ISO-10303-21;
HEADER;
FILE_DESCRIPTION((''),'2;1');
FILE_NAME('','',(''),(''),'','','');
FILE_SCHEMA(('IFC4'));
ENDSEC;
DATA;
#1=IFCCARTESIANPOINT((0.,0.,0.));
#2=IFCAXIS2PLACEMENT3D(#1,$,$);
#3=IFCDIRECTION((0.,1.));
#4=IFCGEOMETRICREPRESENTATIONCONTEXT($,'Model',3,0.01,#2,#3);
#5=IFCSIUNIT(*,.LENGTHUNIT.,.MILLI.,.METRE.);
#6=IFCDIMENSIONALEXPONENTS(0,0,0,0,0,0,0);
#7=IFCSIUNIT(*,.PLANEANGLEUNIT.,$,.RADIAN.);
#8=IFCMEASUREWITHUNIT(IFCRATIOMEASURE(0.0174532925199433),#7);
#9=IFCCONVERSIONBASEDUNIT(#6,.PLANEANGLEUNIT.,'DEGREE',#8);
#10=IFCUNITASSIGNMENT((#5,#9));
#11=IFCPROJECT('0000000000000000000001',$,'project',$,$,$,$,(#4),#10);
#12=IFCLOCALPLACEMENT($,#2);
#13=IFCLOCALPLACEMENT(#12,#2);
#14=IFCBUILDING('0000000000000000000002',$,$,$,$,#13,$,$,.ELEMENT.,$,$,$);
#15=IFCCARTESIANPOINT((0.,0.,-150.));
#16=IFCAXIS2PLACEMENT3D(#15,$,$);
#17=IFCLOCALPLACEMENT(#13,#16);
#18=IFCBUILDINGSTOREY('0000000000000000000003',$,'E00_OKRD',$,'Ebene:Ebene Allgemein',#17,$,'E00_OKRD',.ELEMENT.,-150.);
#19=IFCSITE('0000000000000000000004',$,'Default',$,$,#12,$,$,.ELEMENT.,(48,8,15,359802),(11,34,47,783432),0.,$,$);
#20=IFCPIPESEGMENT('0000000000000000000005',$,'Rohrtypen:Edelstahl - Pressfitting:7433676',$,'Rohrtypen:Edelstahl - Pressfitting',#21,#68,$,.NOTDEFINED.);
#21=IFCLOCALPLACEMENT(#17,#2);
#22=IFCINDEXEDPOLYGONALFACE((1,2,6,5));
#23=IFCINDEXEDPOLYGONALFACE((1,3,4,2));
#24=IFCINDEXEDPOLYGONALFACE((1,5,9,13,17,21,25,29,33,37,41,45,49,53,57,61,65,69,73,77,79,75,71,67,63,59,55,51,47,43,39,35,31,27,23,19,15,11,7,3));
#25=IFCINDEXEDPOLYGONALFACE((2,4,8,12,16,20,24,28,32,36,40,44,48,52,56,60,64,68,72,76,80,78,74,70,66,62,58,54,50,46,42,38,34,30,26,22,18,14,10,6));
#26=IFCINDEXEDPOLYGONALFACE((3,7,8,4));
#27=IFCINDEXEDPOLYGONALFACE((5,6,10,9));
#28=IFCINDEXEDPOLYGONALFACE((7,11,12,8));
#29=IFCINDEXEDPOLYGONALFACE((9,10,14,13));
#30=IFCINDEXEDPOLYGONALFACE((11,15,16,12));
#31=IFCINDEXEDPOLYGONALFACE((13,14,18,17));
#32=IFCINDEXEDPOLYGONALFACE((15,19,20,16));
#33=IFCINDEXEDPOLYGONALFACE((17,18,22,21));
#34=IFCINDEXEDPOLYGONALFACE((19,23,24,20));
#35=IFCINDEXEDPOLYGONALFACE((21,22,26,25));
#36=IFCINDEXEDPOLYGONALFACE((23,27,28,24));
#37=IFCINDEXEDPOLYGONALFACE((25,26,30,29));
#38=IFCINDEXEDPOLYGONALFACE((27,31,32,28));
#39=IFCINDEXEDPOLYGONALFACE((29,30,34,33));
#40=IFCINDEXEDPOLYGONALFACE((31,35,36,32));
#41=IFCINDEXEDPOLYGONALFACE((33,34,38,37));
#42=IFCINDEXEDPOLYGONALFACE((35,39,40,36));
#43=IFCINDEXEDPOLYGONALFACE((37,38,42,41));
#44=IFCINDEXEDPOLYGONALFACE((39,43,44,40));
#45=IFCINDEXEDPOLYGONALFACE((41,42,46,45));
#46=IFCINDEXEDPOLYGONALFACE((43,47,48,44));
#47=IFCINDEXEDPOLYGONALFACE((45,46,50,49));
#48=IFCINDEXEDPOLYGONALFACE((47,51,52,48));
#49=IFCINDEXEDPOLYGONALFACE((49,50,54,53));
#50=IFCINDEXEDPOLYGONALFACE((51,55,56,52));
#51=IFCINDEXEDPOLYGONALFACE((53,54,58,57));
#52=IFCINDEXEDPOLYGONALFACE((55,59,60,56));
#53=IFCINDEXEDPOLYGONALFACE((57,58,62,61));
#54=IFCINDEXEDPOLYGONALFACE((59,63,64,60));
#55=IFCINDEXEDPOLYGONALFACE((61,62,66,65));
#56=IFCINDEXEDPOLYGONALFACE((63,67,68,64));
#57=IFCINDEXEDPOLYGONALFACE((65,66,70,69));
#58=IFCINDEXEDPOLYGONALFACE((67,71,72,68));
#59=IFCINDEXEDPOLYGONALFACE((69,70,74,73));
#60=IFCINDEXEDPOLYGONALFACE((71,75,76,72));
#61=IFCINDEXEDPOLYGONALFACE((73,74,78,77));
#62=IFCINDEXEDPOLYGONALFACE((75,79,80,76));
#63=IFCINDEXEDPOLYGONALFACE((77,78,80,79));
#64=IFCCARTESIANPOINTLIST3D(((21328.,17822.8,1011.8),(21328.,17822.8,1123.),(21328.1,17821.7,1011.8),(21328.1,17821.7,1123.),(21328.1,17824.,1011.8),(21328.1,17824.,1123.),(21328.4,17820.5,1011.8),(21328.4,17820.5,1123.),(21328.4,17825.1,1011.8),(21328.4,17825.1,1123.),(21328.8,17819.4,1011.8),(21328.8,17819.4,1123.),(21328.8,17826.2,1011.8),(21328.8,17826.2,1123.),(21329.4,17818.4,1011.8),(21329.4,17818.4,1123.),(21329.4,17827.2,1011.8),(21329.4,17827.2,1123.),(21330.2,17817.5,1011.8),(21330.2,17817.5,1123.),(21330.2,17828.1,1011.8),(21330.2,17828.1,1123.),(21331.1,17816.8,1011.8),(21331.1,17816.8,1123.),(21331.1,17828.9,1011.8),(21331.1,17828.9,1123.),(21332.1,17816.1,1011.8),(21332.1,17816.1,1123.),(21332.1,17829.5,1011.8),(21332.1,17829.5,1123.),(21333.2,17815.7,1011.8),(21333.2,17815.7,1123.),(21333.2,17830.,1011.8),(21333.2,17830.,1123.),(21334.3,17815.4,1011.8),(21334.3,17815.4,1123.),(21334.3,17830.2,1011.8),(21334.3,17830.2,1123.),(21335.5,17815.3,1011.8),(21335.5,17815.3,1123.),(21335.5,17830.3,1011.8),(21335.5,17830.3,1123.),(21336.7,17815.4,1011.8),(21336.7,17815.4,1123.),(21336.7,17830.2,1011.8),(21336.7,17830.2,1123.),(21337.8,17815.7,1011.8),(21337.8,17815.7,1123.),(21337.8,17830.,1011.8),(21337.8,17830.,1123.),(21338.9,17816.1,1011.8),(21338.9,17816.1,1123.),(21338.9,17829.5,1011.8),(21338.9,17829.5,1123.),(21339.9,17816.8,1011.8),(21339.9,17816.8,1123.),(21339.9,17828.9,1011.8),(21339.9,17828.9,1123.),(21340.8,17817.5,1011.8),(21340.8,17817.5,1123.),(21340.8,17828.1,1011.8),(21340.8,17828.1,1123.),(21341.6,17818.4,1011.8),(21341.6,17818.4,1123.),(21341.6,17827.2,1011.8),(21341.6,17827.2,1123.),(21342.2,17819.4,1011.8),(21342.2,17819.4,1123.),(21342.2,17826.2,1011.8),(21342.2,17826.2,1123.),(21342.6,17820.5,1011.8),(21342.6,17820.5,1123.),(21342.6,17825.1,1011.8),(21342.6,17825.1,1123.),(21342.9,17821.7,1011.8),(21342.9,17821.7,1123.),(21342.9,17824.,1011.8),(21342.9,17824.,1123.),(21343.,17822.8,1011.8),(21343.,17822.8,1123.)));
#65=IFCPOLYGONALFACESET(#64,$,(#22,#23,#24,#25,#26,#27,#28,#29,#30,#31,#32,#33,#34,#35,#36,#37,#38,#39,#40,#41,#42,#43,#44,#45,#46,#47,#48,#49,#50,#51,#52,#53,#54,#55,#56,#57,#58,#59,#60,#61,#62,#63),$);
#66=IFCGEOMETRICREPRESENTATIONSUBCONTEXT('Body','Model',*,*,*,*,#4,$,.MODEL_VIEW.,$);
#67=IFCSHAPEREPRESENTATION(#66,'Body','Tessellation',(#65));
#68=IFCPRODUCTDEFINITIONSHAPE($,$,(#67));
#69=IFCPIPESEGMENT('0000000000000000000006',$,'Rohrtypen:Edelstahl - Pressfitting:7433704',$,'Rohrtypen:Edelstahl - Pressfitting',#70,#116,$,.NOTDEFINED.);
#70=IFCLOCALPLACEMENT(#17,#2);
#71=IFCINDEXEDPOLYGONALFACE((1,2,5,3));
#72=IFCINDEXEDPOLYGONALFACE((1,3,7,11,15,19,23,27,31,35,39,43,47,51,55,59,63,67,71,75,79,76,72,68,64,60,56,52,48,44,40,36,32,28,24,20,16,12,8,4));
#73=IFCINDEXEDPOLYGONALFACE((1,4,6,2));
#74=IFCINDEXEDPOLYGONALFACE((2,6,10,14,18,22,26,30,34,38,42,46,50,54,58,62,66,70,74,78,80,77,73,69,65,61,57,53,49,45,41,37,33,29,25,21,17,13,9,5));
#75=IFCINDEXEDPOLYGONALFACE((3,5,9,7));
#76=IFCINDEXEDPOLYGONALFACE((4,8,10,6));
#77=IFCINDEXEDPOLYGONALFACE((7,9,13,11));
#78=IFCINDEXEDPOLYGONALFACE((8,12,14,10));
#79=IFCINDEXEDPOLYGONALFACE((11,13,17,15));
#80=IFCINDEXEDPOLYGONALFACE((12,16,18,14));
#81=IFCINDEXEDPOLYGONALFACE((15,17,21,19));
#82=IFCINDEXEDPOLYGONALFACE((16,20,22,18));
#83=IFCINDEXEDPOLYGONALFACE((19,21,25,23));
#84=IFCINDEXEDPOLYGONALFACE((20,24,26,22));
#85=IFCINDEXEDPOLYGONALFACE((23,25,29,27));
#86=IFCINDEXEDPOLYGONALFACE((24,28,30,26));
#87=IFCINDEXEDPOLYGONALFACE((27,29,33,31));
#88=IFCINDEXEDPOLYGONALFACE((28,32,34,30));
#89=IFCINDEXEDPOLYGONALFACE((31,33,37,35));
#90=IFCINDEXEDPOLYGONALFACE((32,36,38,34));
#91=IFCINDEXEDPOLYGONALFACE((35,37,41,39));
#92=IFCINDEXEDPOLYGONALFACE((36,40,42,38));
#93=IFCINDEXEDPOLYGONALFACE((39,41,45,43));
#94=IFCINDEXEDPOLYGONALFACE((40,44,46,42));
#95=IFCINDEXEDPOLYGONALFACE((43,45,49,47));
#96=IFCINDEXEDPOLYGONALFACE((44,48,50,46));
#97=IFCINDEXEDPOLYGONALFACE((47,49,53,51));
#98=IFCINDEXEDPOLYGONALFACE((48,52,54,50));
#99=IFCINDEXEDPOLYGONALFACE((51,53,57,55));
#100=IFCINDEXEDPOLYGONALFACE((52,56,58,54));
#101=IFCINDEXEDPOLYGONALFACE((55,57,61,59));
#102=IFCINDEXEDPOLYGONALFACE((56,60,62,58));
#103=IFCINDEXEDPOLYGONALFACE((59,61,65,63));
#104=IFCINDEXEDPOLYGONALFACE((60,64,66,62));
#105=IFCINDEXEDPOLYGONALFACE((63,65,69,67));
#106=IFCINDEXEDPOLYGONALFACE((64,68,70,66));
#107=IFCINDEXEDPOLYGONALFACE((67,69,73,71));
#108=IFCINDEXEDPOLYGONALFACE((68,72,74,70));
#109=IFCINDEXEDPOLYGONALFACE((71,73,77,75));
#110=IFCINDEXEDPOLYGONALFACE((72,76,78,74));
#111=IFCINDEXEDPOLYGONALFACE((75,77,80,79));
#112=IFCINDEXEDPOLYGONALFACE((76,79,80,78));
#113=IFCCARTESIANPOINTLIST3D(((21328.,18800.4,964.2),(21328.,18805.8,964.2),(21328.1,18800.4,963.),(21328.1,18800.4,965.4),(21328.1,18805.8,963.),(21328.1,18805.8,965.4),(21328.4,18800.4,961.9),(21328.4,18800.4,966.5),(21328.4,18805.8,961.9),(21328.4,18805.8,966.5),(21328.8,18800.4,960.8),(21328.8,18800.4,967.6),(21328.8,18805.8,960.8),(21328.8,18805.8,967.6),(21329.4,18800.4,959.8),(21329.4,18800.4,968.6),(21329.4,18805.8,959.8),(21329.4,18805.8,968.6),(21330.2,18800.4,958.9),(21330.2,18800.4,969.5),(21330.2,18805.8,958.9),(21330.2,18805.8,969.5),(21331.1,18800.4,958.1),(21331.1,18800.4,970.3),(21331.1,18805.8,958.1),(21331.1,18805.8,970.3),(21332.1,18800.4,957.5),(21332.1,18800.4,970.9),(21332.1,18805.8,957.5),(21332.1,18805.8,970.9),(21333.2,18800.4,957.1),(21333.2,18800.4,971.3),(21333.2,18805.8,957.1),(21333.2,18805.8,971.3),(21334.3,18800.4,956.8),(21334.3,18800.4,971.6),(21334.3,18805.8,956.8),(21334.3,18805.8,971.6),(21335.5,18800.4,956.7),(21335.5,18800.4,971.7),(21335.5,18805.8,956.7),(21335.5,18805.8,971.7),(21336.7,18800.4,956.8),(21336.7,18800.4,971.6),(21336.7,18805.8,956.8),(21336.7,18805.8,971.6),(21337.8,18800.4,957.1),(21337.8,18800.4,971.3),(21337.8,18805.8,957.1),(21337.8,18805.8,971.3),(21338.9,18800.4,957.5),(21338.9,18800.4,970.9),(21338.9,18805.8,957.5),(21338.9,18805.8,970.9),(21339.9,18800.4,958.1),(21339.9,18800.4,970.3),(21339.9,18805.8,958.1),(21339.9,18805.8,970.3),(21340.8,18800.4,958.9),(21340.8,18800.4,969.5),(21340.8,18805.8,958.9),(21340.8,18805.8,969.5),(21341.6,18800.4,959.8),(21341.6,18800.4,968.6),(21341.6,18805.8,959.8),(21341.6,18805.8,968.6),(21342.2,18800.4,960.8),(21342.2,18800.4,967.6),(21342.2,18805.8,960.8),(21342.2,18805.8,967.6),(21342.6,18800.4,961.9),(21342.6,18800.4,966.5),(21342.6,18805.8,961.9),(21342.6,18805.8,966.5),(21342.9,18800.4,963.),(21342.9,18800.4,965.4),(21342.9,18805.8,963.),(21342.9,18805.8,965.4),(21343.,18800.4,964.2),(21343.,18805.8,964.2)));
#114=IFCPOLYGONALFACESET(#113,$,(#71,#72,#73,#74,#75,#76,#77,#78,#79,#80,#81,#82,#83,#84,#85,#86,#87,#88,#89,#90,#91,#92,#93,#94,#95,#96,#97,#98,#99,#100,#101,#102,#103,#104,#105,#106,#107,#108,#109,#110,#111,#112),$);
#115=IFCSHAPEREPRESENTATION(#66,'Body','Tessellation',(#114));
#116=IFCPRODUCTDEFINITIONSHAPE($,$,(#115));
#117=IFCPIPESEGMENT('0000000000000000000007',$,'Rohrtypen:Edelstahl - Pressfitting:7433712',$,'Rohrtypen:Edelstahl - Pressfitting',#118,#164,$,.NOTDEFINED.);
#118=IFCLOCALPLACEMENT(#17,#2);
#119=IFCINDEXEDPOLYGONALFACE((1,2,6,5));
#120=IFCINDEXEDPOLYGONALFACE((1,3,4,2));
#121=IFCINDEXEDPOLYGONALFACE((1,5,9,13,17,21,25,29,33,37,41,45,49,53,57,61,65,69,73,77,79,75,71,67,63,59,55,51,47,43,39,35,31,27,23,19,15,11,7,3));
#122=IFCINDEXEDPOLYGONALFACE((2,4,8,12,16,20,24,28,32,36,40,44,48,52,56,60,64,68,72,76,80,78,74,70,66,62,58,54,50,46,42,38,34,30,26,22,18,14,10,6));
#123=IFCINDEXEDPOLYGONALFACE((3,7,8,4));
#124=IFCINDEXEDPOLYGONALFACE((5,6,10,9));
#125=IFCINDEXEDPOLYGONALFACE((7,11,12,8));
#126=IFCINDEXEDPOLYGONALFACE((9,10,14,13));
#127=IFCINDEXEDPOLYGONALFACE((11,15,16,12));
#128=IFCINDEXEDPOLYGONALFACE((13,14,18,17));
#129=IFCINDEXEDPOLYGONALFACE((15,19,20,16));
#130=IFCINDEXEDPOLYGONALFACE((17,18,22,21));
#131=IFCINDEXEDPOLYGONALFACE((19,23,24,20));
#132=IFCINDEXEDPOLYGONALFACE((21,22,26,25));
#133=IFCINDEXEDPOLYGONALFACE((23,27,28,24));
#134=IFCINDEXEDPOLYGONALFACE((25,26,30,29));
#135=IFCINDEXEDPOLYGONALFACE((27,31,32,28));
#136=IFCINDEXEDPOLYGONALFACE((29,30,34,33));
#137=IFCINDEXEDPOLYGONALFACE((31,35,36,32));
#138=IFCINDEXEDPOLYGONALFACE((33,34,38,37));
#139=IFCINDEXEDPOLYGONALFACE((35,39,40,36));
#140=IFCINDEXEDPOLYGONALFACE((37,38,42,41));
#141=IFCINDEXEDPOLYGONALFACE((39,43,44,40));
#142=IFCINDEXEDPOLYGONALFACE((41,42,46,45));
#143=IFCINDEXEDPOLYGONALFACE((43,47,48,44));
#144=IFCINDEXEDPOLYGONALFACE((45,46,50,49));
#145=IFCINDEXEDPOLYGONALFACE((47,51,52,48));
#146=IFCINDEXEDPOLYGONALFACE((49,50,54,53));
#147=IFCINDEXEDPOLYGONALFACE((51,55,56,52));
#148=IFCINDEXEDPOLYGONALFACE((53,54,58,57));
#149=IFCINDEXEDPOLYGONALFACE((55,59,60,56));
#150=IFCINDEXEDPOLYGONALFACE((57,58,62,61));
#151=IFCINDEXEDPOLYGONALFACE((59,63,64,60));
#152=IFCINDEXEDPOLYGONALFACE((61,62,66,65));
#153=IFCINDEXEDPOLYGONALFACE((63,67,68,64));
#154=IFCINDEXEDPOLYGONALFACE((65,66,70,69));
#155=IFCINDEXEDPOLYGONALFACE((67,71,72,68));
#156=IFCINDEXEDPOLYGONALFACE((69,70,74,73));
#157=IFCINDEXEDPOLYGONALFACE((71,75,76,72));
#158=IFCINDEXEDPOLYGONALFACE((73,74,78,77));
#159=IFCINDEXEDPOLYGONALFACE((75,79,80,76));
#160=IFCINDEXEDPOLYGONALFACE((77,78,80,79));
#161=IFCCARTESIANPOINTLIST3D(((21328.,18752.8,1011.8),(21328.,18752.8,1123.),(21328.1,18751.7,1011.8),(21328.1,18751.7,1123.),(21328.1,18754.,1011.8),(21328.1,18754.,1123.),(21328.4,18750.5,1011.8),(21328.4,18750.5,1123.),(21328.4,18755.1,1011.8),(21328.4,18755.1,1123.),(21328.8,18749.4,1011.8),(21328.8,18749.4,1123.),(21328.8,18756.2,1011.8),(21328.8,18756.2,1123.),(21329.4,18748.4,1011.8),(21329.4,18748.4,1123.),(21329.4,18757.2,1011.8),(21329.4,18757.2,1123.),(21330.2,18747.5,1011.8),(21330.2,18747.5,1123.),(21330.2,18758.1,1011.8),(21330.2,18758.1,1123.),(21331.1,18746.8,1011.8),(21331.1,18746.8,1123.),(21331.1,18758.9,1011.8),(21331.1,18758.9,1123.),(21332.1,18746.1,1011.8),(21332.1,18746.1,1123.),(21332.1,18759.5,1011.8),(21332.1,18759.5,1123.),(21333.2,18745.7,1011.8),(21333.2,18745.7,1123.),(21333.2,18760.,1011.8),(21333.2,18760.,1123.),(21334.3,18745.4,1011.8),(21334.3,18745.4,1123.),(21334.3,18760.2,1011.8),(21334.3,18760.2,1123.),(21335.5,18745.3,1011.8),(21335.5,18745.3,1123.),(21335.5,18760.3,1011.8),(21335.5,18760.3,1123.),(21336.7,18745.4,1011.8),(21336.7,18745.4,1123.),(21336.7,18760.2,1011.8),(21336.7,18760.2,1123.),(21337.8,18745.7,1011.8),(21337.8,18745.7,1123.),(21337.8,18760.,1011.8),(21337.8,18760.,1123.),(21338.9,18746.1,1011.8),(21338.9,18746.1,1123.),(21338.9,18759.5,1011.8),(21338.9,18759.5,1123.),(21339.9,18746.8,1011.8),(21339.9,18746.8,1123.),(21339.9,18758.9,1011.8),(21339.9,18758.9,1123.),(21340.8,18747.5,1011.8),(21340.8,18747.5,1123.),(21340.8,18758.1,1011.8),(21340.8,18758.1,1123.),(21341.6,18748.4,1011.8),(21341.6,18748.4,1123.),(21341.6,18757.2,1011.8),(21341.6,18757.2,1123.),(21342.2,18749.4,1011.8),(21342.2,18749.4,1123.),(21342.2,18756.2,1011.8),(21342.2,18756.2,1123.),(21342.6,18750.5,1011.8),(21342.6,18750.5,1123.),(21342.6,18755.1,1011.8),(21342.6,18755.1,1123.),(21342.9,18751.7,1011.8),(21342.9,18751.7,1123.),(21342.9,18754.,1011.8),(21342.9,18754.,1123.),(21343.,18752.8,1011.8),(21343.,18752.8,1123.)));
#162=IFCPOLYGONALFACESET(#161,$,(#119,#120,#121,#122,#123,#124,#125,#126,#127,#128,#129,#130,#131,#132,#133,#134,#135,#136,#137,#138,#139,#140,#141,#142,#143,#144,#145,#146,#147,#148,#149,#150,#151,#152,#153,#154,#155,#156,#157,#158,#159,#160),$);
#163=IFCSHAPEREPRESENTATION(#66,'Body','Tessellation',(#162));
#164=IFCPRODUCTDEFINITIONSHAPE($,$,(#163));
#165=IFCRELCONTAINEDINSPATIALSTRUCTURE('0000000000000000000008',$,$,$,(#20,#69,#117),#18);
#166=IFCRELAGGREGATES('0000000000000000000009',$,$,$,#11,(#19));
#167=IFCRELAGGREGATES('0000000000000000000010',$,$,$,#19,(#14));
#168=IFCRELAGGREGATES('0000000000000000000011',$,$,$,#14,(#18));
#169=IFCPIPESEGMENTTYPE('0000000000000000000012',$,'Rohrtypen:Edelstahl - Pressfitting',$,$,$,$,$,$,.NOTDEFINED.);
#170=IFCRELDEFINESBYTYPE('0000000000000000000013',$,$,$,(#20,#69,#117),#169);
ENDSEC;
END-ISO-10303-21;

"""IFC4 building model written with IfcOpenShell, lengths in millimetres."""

from ifc_helpers import new_model, entity, si_unit, converted_unit, direction, frame, origin, place, context, subcontext, project, spatial, indexed_curve, outline, extrude, type_object, element, save


model = new_model("IFC4")

# Units and contexts
model_context = context("Model", 3, precision=0.01, world=origin(), true_north=direction((0.0, 1.0)))
body_context = subcontext(model_context, "Body", "Model", "MODEL_VIEW")
ifc_project = project(units=[si_unit("LENGTHUNIT", "METRE", prefix="MILLI"), converted_unit("PLANEANGLEUNIT", "DEGREE", entity("IfcRatioMeasure", 0.0174532925199433), si_unit("PLANEANGLEUNIT", "RADIAN"), dimensions=[0, 0, 0, 0, 0, 0, 0])], contexts=[model_context])

# Site, building, storey
site_placement = place(None, origin())
site = spatial("IfcSite", under=ifc_project, at=site_placement, Name="Default", CompositionType="ELEMENT", RefLatitude=(48, 8, 15, 359802), RefLongitude=(11, 34, 47, 783432), RefElevation=0.0)
building_placement = place(site_placement, origin())
building = spatial("IfcBuilding", under=site, at=building_placement, CompositionType="ELEMENT")
storey_placement = place(building_placement, frame((0.0, 0.0, -150.0)))
storey = spatial("IfcBuildingStorey", under=building, at=storey_placement, Name="E00_OKRD", ObjectType="Ebene:Ebene Allgemein", LongName="E00_OKRD", CompositionType="ELEMENT", Elevation=-150.0)

# Pipe segments
pipe_segment_type_1 = type_object("IfcPipeSegmentType", Name="Rohrtypen:Edelstahl - Pressfitting", PredefinedType="NOTDEFINED")
pipe_segment_1_placement = place(storey_placement, origin())
element("IfcPipeSegment", 1, at=pipe_segment_1_placement, inside=storey, type_object=pipe_segment_type_1, Name="Rohrtypen:Edelstahl - Pressfitting:7433676", ObjectType="Rohrtypen:Edelstahl - Pressfitting", PredefinedType="NOTDEFINED", context=body_context, shape_type="SweptSolid", body=[
    extrude(outline(indexed_curve([(7.5, 0.0), (7.4, 1.2), (7.1, 2.3), (6.7, 3.4), (6.1, 4.4), (5.3, 5.3), (4.4, 6.1), (3.4, 6.7), (2.3, 7.1), (1.2, 7.4), (0.0, 7.5), (-1.2, 7.4), (-2.3, 7.1), (-3.4, 6.7), (-4.4, 6.1), (-5.3, 5.3), (-6.1, 4.4), (-6.7, 3.4), (-7.1, 2.3), (-7.4, 1.2), (-7.5, 0.0), (-7.4, -1.2), (-7.1, -2.3), (-6.7, -3.4), (-6.1, -4.4), (-5.3, -5.3), (-4.4, -6.1), (-3.4, -6.7), (-2.3, -7.1), (-1.2, -7.4), (0.0, -7.5), (1.2, -7.4), (2.3, -7.1), (3.4, -6.7), (4.4, -6.1), (5.3, -5.3), (6.1, -4.4), (6.7, -3.4), (7.1, -2.3), (7.4, -1.2), (7.5, 0.0)], self_intersect=False)), frame((21335.5, 17822.8, 1011.8), z_axis=(-0.000005, 0.0, 1.0), x_axis=(-1.0, 0.0, -0.000005)), (0.0, 0.0, 1.0), 111.2),
])
pipe_segment_2_placement = place(storey_placement, origin())
element("IfcPipeSegment", 2, at=pipe_segment_2_placement, inside=storey, type_object=pipe_segment_type_1, Name="Rohrtypen:Edelstahl - Pressfitting:7433704", ObjectType="Rohrtypen:Edelstahl - Pressfitting", PredefinedType="NOTDEFINED", context=body_context, shape_type="SweptSolid", body=[
    extrude(outline(indexed_curve([(7.5, 0.0), (7.4, 1.2), (7.1, 2.3), (6.7, 3.4), (6.1, 4.4), (5.3, 5.3), (4.4, 6.1), (3.4, 6.7), (2.3, 7.1), (1.2, 7.4), (0.0, 7.5), (-1.2, 7.4), (-2.3, 7.1), (-3.4, 6.7), (-4.4, 6.1), (-5.3, 5.3), (-6.1, 4.4), (-6.7, 3.4), (-7.1, 2.3), (-7.4, 1.2), (-7.5, 0.0), (-7.4, -1.2), (-7.1, -2.3), (-6.7, -3.4), (-6.1, -4.4), (-5.3, -5.3), (-4.4, -6.1), (-3.4, -6.7), (-2.3, -7.1), (-1.2, -7.4), (0.0, -7.5), (1.2, -7.4), (2.3, -7.1), (3.4, -6.7), (4.4, -6.1), (5.3, -5.3), (6.1, -4.4), (6.7, -3.4), (7.1, -2.3), (7.4, -1.2), (7.5, 0.0)], self_intersect=False)), frame((21335.5, 18800.4, 964.2), z_axis=(0.0, 1.0, 0.0), x_axis=(-1.0, 0.0, 0.0)), (0.0, 0.0, 1.0), 5.4),
])
pipe_segment_3_placement = place(storey_placement, origin())
element("IfcPipeSegment", 3, at=pipe_segment_3_placement, inside=storey, type_object=pipe_segment_type_1, Name="Rohrtypen:Edelstahl - Pressfitting:7433712", ObjectType="Rohrtypen:Edelstahl - Pressfitting", PredefinedType="NOTDEFINED", context=body_context, shape_type="SweptSolid", body=[
    extrude(outline(indexed_curve([(7.5, 0.0), (7.4, 1.2), (7.1, 2.3), (6.7, 3.4), (6.1, 4.4), (5.3, 5.3), (4.4, 6.1), (3.4, 6.7), (2.3, 7.1), (1.2, 7.4), (0.0, 7.5), (-1.2, 7.4), (-2.3, 7.1), (-3.4, 6.7), (-4.4, 6.1), (-5.3, 5.3), (-6.1, 4.4), (-6.7, 3.4), (-7.1, 2.3), (-7.4, 1.2), (-7.5, 0.0), (-7.4, -1.2), (-7.1, -2.3), (-6.7, -3.4), (-6.1, -4.4), (-5.3, -5.3), (-4.4, -6.1), (-3.4, -6.7), (-2.3, -7.1), (-1.2, -7.4), (0.0, -7.5), (1.2, -7.4), (2.3, -7.1), (3.4, -6.7), (4.4, -6.1), (5.3, -5.3), (6.1, -4.4), (6.7, -3.4), (7.1, -2.3), (7.4, -1.2), (7.5, 0.0)], self_intersect=False)), frame((21335.5, 18752.8, 1011.8), z_axis=(-0.000002, 0.0, 1.0), x_axis=(-1.0, 0.0, -0.000002)), (0.0, 0.0, 1.0), 111.2),
])

save(model, "model.ifc")
